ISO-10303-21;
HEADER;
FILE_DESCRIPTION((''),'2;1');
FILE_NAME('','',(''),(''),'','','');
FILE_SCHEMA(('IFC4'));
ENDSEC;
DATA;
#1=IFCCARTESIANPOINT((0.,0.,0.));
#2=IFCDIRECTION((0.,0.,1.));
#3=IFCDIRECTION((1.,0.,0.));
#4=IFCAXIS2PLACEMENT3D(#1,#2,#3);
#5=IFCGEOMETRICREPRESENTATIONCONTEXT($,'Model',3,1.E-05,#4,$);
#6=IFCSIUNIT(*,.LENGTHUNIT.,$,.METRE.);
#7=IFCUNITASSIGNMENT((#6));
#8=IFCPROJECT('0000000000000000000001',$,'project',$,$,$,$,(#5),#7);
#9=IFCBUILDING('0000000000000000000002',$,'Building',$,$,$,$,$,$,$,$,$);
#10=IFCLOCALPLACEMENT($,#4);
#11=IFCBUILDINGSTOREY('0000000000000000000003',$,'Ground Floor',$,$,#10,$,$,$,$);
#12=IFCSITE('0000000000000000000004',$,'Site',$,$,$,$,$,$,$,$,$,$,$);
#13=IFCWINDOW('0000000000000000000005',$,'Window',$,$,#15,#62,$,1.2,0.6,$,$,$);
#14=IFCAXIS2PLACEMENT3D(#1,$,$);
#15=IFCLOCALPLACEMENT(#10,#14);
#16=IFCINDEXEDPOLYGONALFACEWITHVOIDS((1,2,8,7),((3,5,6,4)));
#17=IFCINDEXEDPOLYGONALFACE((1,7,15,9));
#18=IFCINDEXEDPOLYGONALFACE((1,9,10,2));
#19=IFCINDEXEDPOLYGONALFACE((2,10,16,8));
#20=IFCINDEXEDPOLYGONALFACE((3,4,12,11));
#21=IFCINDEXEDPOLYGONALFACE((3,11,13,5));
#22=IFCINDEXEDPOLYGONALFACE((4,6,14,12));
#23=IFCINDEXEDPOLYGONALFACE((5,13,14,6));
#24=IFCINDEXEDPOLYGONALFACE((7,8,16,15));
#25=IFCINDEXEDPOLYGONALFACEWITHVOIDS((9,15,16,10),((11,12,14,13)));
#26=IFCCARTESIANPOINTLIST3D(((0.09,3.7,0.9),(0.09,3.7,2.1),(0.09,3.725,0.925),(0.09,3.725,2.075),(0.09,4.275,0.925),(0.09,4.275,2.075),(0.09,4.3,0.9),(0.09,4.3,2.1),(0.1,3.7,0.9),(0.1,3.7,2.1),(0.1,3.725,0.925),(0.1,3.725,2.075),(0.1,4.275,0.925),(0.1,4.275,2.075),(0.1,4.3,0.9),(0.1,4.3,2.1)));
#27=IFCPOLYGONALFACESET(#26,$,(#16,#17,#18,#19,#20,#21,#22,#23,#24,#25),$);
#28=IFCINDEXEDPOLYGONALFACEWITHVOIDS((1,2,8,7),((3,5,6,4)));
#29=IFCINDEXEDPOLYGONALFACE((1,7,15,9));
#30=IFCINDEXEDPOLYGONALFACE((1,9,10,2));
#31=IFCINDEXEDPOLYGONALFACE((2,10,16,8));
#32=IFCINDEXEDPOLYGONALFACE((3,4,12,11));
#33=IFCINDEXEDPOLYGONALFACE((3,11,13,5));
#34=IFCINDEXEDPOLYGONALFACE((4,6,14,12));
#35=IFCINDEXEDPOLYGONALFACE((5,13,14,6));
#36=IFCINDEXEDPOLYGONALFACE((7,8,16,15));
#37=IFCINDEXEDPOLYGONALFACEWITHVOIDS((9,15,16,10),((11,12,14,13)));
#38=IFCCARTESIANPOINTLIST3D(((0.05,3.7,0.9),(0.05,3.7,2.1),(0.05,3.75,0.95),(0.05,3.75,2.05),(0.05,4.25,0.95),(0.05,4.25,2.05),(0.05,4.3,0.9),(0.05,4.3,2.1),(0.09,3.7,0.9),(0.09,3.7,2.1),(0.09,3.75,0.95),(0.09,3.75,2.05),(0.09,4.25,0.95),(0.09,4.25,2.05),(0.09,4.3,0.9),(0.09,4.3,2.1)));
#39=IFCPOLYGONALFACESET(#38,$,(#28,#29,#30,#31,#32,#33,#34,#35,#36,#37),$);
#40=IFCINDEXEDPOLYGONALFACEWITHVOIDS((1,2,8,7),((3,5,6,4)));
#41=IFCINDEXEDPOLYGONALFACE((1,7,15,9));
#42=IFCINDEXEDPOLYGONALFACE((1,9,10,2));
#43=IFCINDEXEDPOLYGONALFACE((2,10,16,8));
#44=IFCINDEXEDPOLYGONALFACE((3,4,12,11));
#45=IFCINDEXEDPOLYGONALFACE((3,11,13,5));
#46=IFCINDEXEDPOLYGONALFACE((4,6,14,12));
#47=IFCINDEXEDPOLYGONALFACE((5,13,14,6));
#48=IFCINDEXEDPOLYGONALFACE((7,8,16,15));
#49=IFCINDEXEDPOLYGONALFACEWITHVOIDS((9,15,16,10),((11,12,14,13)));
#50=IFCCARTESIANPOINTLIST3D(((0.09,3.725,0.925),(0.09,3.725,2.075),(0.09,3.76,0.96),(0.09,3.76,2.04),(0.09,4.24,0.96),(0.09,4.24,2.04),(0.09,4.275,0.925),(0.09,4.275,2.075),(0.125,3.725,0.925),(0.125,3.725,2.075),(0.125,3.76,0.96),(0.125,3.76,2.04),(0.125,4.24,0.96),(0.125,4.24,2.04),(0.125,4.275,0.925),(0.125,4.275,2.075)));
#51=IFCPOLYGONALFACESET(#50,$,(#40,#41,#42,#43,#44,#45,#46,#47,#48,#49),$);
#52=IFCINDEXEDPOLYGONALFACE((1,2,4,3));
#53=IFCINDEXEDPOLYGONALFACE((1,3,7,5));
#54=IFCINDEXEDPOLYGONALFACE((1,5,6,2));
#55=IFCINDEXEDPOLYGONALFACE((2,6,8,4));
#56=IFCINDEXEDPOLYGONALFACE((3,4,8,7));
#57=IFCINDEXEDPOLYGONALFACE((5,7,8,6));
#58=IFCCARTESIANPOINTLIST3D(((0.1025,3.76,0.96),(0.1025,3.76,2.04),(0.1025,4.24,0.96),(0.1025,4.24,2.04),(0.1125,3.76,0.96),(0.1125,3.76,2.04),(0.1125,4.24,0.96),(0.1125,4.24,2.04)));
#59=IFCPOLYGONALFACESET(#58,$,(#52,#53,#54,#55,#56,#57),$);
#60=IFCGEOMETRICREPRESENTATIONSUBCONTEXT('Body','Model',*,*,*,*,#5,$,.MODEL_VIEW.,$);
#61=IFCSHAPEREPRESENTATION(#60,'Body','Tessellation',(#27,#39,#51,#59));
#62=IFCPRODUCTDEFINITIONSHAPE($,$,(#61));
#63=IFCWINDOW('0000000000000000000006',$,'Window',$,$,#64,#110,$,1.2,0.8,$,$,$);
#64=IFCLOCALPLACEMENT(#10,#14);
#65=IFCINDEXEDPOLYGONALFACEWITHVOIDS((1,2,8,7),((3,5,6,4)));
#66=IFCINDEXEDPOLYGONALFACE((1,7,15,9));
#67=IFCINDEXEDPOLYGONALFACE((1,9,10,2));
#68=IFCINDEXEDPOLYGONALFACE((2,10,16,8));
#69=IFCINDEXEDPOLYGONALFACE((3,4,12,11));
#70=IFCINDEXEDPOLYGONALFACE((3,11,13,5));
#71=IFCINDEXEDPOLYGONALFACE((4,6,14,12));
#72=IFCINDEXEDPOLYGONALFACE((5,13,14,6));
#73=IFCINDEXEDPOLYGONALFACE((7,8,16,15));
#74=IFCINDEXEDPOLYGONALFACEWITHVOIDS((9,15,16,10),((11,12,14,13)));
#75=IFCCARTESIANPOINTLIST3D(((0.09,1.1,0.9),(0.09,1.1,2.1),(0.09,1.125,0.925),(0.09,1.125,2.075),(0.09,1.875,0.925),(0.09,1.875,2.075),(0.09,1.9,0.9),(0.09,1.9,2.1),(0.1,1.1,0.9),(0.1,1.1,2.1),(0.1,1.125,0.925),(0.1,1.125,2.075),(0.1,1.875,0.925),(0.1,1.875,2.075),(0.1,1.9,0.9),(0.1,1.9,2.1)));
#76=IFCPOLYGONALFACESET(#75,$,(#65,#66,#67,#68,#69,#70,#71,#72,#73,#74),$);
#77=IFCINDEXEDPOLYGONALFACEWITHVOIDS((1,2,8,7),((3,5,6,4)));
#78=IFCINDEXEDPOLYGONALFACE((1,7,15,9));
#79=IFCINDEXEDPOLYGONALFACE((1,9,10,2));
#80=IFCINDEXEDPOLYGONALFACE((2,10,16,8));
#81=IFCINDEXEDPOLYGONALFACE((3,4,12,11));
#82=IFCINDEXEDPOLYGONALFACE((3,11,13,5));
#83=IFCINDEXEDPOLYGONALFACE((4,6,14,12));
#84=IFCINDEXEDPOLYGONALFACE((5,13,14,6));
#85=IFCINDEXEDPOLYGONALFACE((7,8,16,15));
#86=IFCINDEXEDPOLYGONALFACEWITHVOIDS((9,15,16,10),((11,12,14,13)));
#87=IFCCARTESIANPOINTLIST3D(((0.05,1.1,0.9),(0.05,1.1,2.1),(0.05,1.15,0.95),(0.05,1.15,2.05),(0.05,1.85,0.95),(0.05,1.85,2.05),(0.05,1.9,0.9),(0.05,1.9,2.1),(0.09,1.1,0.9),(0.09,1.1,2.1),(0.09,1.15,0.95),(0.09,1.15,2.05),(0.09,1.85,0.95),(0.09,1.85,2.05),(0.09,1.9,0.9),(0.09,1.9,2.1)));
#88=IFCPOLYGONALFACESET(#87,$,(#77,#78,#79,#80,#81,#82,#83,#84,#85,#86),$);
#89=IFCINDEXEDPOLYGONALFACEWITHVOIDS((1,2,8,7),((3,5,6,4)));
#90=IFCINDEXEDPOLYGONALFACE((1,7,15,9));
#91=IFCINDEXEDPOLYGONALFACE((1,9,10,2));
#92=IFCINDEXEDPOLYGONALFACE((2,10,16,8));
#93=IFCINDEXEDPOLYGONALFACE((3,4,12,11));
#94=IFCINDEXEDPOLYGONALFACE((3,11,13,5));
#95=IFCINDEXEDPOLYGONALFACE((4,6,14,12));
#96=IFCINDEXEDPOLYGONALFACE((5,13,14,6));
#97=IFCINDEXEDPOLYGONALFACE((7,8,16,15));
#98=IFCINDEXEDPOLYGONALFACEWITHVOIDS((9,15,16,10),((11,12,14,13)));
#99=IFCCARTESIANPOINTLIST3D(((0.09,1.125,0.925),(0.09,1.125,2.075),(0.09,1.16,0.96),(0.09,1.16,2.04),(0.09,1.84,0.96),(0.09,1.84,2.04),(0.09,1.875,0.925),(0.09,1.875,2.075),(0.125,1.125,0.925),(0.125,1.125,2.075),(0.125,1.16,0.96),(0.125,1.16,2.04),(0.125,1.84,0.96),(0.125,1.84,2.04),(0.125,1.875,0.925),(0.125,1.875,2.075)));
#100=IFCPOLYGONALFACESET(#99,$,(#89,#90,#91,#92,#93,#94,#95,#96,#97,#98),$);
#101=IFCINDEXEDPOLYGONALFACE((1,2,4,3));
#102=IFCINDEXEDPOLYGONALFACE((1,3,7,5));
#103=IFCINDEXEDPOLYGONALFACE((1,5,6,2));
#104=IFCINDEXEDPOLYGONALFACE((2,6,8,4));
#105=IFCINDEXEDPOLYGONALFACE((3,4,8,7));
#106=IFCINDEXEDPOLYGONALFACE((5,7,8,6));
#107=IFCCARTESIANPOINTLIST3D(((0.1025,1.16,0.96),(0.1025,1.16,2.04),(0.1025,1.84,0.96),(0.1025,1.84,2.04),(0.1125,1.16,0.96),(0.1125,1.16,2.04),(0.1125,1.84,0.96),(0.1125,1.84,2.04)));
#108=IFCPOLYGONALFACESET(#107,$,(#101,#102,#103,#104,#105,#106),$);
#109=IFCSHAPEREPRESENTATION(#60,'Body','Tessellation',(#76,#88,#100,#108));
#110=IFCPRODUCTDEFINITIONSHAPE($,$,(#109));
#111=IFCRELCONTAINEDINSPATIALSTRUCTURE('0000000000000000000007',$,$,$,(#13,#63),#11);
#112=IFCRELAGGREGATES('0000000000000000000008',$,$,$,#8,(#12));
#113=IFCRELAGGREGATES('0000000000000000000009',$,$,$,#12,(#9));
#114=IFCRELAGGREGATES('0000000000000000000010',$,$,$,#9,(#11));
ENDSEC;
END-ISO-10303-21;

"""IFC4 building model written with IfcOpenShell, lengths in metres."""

from ifc_helpers import new_model, si_unit, frame, origin_with_axes, place, context, subcontext, project, spatial, line, indexed_curve, outline, extrude, element, save


model = new_model("IFC4")

# Units and contexts
model_context = context("Model", 3, precision=1e-05, world=origin_with_axes())
body_context = subcontext(model_context, "Body", "Model", "MODEL_VIEW")
ifc_project = project(units=[si_unit("LENGTHUNIT", "METRE")], contexts=[model_context])

# Site, building, storey
site = spatial("IfcSite", under=ifc_project, Name="Site")
building = spatial("IfcBuilding", under=site, Name="Building")
storey_placement = place(None, origin_with_axes())
storey = spatial("IfcBuildingStorey", under=building, at=storey_placement, Name="Ground Floor")

# Windows
window_1_placement = place(storey_placement, frame((0.0, 4.3, 0.9), z_axis=(0.0, 0.0, 1.0), x_axis=(0.0, -1.0, 0.0)))
element("IfcWindow", 1, at=window_1_placement, inside=storey, Name="Window", OverallHeight=1.2, OverallWidth=0.6, context=body_context, shape_type="SweptSolid", body=[
    extrude(outline(indexed_curve([(0.0, 0.0), (0.6, 0.0), (0.6, 1.2), (0.0, 1.2)], segments=[line(1, 2, 3, 4, 1)]), holes=[indexed_curve([(0.025, 0.025), (0.575, 0.025), (0.575, 1.175), (0.025, 1.175)], segments=[line(1, 2, 3, 4, 1)])]), frame((0.0, 0.09, 0.0), z_axis=(0.0, -1.0, 0.0), x_axis=(1.0, 0.0, 0.0)), (0.0, 0.0, -1.0), 0.01),
    extrude(outline(indexed_curve([(0.0, 0.0), (0.6, 0.0), (0.6, 1.2), (0.0, 1.2)], segments=[line(1, 2, 3, 4, 1)]), holes=[indexed_curve([(0.05, 0.05), (0.55, 0.05), (0.55, 1.15), (0.05, 1.15)], segments=[line(1, 2, 3, 4, 1)])]), frame((0.0, 0.05, 0.0), z_axis=(0.0, -1.0, 0.0), x_axis=(1.0, 0.0, 0.0)), (0.0, 0.0, -1.0), 0.04),
    extrude(outline(indexed_curve([(0.0, 0.0), (0.55, 0.0), (0.55, 1.15), (0.0, 1.15)], segments=[line(1, 2, 3, 4, 1)]), holes=[indexed_curve([(0.035, 0.035), (0.515, 0.035), (0.515, 1.115), (0.035, 1.115)], segments=[line(1, 2, 3, 4, 1)])]), frame((0.025, 0.09, 0.025), z_axis=(0.0, -1.0, 0.0), x_axis=(1.0, 0.0, 0.0)), (0.0, 0.0, -1.0), 0.035),
    extrude(outline(indexed_curve([(0.035, 0.035), (0.515, 0.035), (0.515, 1.115), (0.035, 1.115)], segments=[line(1, 2, 3, 4, 1)])), frame((0.025, 0.1025, 0.025), z_axis=(0.0, -1.0, 0.0), x_axis=(1.0, 0.0, 0.0)), (0.0, 0.0, -1.0), 0.01),
])
window_2_placement = place(storey_placement, frame((0.0, 1.9, 0.9), z_axis=(0.0, 0.0, 1.0), x_axis=(0.0, -1.0, 0.0)))
element("IfcWindow", 2, at=window_2_placement, inside=storey, Name="Window", OverallHeight=1.2, OverallWidth=0.8, context=body_context, shape_type="SweptSolid", body=[
    extrude(outline(indexed_curve([(0.0, 0.0), (0.8, 0.0), (0.8, 1.2), (0.0, 1.2)], segments=[line(1, 2, 3, 4, 1)]), holes=[indexed_curve([(0.025, 0.025), (0.775, 0.025), (0.775, 1.175), (0.025, 1.175)], segments=[line(1, 2, 3, 4, 1)])]), frame((0.0, 0.09, 0.0), z_axis=(0.0, -1.0, 0.0), x_axis=(1.0, 0.0, 0.0)), (0.0, 0.0, -1.0), 0.01),
    extrude(outline(indexed_curve([(0.0, 0.0), (0.8, 0.0), (0.8, 1.2), (0.0, 1.2)], segments=[line(1, 2, 3, 4, 1)]), holes=[indexed_curve([(0.05, 0.05), (0.75, 0.05), (0.75, 1.15), (0.05, 1.15)], segments=[line(1, 2, 3, 4, 1)])]), frame((0.0, 0.05, 0.0), z_axis=(0.0, -1.0, 0.0), x_axis=(1.0, 0.0, 0.0)), (0.0, 0.0, -1.0), 0.04),
    extrude(outline(indexed_curve([(0.0, 0.0), (0.75, 0.0), (0.75, 1.15), (0.0, 1.15)], segments=[line(1, 2, 3, 4, 1)]), holes=[indexed_curve([(0.035, 0.035), (0.715, 0.035), (0.715, 1.115), (0.035, 1.115)], segments=[line(1, 2, 3, 4, 1)])]), frame((0.025, 0.09, 0.025), z_axis=(0.0, -1.0, 0.0), x_axis=(1.0, 0.0, 0.0)), (0.0, 0.0, -1.0), 0.035),
    extrude(outline(indexed_curve([(0.035, 0.035), (0.715, 0.035), (0.715, 1.115), (0.035, 1.115)], segments=[line(1, 2, 3, 4, 1)])), frame((0.025, 0.1025, 0.025), z_axis=(0.0, -1.0, 0.0), x_axis=(1.0, 0.0, 0.0)), (0.0, 0.0, -1.0), 0.01),
])

save(model, "model.ifc")
